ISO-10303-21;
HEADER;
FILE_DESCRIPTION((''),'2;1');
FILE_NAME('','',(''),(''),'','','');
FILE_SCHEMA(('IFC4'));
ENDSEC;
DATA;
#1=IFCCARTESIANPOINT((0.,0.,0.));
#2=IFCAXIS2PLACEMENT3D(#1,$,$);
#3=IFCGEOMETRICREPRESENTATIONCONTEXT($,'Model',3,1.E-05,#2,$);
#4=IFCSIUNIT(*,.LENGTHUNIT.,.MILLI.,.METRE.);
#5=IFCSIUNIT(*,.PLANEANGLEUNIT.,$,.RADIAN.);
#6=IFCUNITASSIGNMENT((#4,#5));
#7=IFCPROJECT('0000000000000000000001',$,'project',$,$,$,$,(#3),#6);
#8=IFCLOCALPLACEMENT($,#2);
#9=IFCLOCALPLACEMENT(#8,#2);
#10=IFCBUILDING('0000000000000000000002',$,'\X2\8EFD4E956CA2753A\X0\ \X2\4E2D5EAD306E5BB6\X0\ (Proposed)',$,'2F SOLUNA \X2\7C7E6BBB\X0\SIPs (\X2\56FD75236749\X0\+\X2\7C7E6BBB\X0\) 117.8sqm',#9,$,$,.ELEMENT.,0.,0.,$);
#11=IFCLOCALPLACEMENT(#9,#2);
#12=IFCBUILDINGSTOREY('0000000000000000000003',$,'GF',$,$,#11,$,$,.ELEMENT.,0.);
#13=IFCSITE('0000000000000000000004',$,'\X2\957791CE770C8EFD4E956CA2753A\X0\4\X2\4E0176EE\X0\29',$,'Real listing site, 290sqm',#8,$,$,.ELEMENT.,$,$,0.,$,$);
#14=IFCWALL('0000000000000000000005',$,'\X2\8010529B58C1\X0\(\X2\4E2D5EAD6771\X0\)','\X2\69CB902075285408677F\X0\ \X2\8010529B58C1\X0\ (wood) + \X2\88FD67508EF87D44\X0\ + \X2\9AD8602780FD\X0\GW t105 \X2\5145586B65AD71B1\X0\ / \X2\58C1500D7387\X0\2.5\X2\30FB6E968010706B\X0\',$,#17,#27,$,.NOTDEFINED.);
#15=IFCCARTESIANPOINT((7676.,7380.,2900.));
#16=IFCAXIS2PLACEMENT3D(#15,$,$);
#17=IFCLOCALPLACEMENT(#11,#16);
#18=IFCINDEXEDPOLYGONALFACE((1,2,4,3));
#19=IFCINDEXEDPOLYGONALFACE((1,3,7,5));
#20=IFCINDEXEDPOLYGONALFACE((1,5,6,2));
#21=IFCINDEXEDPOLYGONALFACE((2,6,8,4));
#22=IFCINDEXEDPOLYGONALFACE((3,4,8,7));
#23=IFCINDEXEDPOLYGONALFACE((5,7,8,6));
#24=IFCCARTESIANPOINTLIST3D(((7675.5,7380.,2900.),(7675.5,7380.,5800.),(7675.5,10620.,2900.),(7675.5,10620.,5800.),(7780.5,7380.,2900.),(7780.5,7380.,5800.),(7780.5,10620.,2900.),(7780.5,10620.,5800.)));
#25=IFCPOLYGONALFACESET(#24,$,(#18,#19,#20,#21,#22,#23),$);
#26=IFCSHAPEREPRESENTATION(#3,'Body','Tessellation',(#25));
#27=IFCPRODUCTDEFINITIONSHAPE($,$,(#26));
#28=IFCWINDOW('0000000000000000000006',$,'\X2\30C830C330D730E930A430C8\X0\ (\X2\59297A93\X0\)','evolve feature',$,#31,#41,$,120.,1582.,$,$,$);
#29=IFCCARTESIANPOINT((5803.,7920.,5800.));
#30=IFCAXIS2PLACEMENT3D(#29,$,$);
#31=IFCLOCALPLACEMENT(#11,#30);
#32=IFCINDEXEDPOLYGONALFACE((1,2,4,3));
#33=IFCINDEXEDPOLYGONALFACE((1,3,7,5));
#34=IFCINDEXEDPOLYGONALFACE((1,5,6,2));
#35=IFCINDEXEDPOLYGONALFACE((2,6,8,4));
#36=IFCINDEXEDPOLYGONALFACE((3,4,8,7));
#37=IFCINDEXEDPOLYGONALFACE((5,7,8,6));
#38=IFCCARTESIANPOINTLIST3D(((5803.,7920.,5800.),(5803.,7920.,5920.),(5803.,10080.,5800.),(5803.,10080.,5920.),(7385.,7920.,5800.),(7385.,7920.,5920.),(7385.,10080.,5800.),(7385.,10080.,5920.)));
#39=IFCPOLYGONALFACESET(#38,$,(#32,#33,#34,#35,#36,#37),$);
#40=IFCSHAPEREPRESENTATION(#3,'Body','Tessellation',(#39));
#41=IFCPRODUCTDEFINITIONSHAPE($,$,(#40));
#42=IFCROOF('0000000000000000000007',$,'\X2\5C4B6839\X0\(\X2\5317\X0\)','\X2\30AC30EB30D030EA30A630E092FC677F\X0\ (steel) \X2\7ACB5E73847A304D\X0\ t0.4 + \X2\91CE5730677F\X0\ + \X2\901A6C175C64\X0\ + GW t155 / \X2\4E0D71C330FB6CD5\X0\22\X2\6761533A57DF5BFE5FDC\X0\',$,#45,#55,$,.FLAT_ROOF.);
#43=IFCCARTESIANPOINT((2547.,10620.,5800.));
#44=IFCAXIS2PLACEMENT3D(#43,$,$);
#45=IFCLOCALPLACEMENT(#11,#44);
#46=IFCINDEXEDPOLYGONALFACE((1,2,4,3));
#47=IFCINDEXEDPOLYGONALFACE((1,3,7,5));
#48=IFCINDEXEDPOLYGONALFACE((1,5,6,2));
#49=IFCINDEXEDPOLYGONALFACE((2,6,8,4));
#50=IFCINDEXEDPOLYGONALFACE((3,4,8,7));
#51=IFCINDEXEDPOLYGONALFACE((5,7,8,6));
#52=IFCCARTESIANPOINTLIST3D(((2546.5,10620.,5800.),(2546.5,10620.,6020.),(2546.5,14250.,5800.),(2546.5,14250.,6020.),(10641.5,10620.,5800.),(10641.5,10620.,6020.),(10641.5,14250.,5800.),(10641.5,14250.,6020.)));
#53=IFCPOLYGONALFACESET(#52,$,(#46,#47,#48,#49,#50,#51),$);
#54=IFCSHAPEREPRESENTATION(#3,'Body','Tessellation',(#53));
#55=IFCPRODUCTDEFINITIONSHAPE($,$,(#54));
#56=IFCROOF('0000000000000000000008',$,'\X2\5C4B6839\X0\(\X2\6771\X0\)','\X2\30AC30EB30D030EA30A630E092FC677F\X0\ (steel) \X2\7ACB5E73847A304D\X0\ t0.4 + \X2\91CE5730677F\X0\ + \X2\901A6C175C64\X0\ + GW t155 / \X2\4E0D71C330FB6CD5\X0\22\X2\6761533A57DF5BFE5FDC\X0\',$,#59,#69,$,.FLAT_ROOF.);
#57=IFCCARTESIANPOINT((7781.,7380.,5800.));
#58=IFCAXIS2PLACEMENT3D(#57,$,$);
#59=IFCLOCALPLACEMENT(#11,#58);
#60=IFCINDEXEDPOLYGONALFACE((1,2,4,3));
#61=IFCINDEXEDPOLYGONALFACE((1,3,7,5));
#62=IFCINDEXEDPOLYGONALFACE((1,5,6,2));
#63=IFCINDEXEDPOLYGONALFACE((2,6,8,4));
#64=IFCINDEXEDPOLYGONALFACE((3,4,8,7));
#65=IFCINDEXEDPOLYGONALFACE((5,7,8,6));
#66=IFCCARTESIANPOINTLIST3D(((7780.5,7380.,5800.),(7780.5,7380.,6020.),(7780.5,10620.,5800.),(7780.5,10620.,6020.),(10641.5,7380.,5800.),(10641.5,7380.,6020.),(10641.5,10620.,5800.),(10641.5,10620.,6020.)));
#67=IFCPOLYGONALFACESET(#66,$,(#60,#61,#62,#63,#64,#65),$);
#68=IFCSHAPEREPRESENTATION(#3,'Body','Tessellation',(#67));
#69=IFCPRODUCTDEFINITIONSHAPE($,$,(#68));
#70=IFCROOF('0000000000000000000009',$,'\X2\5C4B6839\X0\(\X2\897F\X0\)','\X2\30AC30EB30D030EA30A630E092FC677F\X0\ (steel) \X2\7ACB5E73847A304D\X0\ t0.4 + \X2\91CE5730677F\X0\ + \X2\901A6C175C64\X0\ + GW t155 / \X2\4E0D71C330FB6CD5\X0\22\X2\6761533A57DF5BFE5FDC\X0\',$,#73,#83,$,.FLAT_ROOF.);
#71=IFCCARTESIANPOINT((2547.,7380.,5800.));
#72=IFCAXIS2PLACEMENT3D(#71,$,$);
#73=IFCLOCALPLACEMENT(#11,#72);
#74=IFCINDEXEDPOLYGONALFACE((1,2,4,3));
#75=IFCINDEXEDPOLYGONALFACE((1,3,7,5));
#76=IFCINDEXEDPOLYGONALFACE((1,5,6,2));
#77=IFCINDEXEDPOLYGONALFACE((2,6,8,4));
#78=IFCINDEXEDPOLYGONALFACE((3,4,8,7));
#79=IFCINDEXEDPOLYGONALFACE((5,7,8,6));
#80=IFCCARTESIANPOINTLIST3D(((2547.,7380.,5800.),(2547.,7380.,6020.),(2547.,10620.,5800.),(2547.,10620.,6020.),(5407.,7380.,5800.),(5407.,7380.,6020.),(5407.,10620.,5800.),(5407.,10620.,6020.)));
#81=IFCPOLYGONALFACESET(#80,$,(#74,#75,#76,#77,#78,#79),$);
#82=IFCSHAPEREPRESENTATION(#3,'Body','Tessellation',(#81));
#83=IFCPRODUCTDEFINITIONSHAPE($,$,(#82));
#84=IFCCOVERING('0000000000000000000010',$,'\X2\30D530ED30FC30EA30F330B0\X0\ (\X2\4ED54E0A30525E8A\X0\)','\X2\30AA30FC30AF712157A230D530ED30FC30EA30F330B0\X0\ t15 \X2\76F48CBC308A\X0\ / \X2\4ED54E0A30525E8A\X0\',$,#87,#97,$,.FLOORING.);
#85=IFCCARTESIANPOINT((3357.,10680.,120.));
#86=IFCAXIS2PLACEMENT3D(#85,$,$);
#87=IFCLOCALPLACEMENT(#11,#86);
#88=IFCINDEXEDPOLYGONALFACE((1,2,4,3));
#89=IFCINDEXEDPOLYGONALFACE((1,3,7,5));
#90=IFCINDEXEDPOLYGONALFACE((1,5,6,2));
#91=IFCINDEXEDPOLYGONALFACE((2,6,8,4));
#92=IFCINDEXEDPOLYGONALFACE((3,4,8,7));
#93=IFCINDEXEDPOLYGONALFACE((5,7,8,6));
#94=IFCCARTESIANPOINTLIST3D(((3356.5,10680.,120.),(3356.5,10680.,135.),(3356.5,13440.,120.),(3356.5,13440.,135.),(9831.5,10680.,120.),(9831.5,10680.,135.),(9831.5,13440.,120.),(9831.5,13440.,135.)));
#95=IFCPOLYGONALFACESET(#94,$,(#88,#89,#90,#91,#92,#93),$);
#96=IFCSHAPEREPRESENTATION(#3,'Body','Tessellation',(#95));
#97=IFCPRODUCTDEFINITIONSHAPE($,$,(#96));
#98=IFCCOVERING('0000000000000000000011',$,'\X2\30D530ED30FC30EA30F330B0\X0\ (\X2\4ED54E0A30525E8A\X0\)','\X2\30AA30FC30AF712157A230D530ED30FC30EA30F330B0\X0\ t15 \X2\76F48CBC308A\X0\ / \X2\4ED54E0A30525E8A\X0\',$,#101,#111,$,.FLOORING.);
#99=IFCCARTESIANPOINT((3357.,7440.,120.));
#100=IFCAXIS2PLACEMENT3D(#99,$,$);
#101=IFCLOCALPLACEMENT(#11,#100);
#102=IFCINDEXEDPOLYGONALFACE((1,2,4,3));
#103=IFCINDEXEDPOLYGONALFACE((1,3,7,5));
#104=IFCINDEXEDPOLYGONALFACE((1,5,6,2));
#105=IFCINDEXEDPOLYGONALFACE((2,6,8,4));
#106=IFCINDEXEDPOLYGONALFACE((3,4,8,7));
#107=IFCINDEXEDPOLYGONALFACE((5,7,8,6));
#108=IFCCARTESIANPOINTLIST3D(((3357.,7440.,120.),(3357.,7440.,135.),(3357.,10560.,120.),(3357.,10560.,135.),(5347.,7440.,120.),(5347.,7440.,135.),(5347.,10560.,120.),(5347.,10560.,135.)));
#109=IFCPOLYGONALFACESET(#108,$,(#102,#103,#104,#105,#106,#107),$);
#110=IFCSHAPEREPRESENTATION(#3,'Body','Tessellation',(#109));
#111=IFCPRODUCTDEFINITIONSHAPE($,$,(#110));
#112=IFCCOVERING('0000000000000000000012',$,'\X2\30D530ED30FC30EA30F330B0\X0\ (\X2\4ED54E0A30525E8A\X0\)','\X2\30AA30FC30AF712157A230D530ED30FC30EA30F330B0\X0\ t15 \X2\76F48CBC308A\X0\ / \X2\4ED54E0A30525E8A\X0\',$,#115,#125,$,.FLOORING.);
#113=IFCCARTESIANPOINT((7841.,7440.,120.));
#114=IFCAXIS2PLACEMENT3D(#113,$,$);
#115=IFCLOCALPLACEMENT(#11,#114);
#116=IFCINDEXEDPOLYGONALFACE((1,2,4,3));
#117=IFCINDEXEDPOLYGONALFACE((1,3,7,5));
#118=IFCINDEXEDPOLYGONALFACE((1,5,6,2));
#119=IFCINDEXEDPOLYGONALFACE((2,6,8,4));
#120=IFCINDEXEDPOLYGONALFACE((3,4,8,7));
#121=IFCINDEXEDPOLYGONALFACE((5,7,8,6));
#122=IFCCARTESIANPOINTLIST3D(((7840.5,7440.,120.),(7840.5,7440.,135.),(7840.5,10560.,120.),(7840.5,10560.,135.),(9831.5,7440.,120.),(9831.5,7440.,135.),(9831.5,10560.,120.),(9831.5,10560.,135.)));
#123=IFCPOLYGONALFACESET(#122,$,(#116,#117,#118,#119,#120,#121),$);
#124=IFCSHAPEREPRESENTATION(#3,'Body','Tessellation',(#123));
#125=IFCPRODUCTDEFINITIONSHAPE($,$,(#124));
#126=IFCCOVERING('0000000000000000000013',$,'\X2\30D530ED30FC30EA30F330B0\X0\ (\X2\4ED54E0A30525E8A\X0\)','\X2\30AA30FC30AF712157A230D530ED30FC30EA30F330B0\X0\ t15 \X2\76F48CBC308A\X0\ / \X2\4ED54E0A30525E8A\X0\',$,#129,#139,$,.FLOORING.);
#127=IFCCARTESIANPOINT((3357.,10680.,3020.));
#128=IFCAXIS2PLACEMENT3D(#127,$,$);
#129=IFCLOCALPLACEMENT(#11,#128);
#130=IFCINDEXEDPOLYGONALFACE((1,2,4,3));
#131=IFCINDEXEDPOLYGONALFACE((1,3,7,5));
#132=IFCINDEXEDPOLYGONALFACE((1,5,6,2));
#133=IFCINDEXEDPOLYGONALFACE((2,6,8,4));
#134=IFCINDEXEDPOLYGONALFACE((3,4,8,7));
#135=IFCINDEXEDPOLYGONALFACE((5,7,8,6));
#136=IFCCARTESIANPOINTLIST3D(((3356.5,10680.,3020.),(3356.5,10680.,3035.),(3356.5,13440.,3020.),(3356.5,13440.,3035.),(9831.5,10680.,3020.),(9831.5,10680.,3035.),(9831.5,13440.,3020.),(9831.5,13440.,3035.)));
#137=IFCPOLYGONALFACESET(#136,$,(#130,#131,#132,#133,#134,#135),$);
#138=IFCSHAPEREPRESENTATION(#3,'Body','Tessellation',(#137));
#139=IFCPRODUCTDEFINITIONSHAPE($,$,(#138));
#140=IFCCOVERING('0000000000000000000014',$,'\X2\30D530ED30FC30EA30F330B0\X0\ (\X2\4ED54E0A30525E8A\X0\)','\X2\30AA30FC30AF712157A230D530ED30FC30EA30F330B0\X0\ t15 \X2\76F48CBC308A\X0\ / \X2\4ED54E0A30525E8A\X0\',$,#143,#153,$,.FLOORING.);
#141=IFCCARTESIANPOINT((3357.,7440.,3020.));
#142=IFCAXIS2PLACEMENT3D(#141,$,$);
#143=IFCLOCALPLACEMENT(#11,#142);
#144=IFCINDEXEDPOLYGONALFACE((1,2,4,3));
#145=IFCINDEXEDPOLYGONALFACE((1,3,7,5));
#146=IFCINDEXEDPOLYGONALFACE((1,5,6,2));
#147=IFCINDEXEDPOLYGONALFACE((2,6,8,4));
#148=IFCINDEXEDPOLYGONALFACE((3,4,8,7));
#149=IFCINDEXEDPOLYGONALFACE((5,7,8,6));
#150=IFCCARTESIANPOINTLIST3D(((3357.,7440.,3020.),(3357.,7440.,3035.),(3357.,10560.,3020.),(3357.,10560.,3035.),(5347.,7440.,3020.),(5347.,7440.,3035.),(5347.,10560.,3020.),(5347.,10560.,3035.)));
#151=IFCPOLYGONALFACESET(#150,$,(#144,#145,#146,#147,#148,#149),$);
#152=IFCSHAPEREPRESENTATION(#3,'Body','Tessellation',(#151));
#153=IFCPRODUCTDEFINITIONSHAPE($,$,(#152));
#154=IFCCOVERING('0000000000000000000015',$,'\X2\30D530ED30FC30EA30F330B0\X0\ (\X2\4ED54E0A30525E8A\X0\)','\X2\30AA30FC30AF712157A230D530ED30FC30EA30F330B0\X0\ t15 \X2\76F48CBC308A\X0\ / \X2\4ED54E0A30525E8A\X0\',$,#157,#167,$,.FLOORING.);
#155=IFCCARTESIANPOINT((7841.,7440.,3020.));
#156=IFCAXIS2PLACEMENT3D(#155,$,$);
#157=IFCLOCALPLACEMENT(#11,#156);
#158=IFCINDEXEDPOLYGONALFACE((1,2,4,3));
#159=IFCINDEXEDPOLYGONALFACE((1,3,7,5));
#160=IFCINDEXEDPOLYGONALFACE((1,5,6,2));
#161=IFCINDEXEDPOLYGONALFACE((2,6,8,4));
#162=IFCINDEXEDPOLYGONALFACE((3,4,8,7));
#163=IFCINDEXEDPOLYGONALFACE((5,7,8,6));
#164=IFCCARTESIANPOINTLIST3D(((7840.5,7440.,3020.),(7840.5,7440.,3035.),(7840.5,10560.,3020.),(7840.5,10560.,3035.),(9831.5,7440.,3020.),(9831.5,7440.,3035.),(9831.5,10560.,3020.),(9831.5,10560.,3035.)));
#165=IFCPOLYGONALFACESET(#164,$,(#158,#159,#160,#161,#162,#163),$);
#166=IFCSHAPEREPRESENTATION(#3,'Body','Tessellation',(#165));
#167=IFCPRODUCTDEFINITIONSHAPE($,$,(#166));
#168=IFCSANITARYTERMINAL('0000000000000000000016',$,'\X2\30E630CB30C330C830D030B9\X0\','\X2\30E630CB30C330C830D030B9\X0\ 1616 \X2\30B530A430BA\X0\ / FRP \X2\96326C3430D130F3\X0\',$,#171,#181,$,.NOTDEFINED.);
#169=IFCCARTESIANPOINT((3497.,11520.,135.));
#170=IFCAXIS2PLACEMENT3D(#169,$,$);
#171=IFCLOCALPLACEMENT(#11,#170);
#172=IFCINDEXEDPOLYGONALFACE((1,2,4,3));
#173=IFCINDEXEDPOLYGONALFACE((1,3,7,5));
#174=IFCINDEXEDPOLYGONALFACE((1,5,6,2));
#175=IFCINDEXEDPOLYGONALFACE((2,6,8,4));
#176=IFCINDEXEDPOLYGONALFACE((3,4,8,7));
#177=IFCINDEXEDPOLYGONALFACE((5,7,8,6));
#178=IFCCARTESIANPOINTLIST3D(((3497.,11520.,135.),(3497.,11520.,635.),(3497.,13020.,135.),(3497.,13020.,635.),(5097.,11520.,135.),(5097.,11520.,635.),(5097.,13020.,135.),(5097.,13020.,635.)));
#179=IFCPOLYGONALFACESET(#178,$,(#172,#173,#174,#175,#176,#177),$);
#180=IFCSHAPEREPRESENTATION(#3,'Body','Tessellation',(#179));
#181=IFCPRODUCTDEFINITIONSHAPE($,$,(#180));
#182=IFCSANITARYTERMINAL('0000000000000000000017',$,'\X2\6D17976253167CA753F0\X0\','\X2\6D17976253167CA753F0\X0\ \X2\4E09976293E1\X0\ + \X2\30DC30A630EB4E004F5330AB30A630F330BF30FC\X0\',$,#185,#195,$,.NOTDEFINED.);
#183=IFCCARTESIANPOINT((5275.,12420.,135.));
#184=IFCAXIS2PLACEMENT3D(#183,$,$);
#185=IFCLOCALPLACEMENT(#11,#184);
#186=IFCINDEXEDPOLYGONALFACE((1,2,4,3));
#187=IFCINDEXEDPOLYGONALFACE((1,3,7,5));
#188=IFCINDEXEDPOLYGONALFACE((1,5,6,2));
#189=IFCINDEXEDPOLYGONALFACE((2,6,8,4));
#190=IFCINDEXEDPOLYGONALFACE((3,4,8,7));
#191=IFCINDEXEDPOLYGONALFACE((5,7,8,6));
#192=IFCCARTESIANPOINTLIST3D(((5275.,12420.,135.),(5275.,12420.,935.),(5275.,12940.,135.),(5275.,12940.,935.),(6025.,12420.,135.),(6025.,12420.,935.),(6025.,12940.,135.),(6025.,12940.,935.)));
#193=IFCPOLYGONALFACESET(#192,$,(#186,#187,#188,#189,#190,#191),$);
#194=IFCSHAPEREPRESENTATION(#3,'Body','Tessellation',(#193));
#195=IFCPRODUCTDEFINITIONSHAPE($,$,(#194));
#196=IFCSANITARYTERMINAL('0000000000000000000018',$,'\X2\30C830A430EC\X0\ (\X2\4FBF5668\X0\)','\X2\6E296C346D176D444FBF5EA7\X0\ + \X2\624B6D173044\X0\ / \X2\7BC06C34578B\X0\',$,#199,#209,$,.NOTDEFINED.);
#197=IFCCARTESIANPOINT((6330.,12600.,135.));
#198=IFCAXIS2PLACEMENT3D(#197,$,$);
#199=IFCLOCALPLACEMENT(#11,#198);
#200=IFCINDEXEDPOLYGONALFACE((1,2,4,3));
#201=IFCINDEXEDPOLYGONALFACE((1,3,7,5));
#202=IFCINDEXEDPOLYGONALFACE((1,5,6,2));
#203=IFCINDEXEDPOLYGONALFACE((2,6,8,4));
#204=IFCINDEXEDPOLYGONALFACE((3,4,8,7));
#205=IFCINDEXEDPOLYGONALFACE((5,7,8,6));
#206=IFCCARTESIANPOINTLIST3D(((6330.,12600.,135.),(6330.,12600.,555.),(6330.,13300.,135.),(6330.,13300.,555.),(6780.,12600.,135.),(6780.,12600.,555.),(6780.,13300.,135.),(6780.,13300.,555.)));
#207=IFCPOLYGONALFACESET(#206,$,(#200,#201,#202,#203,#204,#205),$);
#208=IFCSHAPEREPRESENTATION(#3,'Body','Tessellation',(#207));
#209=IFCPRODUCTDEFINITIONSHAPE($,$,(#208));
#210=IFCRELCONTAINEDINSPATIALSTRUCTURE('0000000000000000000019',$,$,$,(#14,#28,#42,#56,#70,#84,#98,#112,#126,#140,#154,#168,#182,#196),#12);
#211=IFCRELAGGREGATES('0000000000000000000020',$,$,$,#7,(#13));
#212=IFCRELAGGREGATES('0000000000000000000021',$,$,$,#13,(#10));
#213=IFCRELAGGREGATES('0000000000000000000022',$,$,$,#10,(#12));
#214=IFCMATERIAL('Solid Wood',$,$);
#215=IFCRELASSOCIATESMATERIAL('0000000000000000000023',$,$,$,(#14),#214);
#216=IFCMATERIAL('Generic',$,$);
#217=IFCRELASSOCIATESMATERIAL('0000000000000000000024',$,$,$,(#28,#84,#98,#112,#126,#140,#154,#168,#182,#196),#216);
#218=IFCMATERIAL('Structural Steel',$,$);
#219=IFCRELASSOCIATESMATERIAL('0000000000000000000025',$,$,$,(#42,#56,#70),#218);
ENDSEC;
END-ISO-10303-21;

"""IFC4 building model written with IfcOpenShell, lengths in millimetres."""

from ifc_helpers import new_model, si_unit, frame, frame_2d, origin, place, context, project, spatial, rectangle, extrude, material, element, save


model = new_model("IFC4")

# Units and contexts
model_context = context("Model", 3, precision=1e-05, world=origin())
ifc_project = project(units=[si_unit("LENGTHUNIT", "METRE", prefix="MILLI"), si_unit("PLANEANGLEUNIT", "RADIAN")], contexts=[model_context])

# Site, building, storey
site_placement = place(None, origin())
site = spatial("IfcSite", under=ifc_project, at=site_placement, Name="長野県軽井沢町4丁目29", ObjectType="Real listing site, 290sqm", CompositionType="ELEMENT", RefElevation=0.0)
building_placement = place(site_placement, origin())
building = spatial("IfcBuilding", under=site, at=building_placement, Name="軽井沢町 中庭の家 (Proposed)", ObjectType="2F SOLUNA 籾殻SIPs (国産杉+籾殻) 117.8sqm", CompositionType="ELEMENT", ElevationOfRefHeight=0.0, ElevationOfTerrain=0.0)
storey_placement = place(building_placement, origin())
storey = spatial("IfcBuildingStorey", under=building, at=storey_placement, Name="GF", CompositionType="ELEMENT", Elevation=0.0)

# Shared definitions
ifc_material_1 = material(Name="Solid Wood")

# Wall
wall_1_placement = place(storey_placement, frame((7676.0, 7380.0, 2900.0)))
element("IfcWall", 1, at=wall_1_placement, inside=storey, material=ifc_material_1, Name="耐力壁(中庭東)", Description="構造用合板 耐力壁 (wood) + 製材軸組 + 高性能GW t105 充填断熱 / 壁倍率2.5・準耐火", PredefinedType="NOTDEFINED", context=model_context, shape_type="SweptSolid", body=[
    extrude(rectangle(XDim=105.0, YDim=3240.0, at=frame_2d((52.0, 1620.0))), frame((7676.0, 7380.0, 2900.0)), (0.0, 0.0, 1.0), 2900.0),
])

# Window
ifc_material_2 = material(Name="Generic")
window_1_placement = place(storey_placement, frame((5803.0, 7920.0, 5800.0)))
element("IfcWindow", 2, at=window_1_placement, inside=storey, material=ifc_material_2, Name="トップライト (天窓)", Description="evolve feature", OverallHeight=120.0, OverallWidth=1582.0, context=model_context, shape_type="SweptSolid", body=[
    extrude(rectangle(XDim=1582.0, YDim=2160.0, at=frame_2d((791.0, 1080.0))), frame((5803.0, 7920.0, 5800.0)), (0.0, 0.0, 1.0), 120.0),
])

# Roofs
ifc_material_3 = material(Name="Structural Steel")
roof_1_placement = place(storey_placement, frame((2547.0, 10620.0, 5800.0)))
element("IfcRoof", 3, at=roof_1_placement, inside=storey, material=ifc_material_3, Name="屋根(北)", Description="ガルバリウム鋼板 (steel) 立平葺き t0.4 + 野地板 + 通気層 + GW t155 / 不燃・法22条区域対応", PredefinedType="FLAT_ROOF", context=model_context, shape_type="SweptSolid", body=[
    extrude(rectangle(XDim=8095.0, YDim=3630.0, at=frame_2d((4047.0, 1815.0))), frame((2547.0, 10620.0, 5800.0)), (0.0, 0.0, 1.0), 220.0),
])
roof_2_placement = place(storey_placement, frame((7781.0, 7380.0, 5800.0)))
element("IfcRoof", 4, at=roof_2_placement, inside=storey, material=ifc_material_3, Name="屋根(東)", Description="ガルバリウム鋼板 (steel) 立平葺き t0.4 + 野地板 + 通気層 + GW t155 / 不燃・法22条区域対応", PredefinedType="FLAT_ROOF", context=model_context, shape_type="SweptSolid", body=[
    extrude(rectangle(XDim=2861.0, YDim=3240.0, at=frame_2d((1430.0, 1620.0))), frame((7781.0, 7380.0, 5800.0)), (0.0, 0.0, 1.0), 220.0),
])
roof_3_placement = place(storey_placement, frame((2547.0, 7380.0, 5800.0)))
element("IfcRoof", 5, at=roof_3_placement, inside=storey, material=ifc_material_3, Name="屋根(西)", Description="ガルバリウム鋼板 (steel) 立平葺き t0.4 + 野地板 + 通気層 + GW t155 / 不燃・法22条区域対応", PredefinedType="FLAT_ROOF", context=model_context, shape_type="SweptSolid", body=[
    extrude(rectangle(XDim=2860.0, YDim=3240.0, at=frame_2d((1430.0, 1620.0))), frame((2547.0, 7380.0, 5800.0)), (0.0, 0.0, 1.0), 220.0),
])

# Coverings
covering_1_placement = place(storey_placement, frame((3357.0, 10680.0, 120.0)))
element("IfcCovering", 6, at=covering_1_placement, inside=storey, material=ifc_material_2, Name="フローリング (仕上げ床)", Description="オーク無垢フローリング t15 直貼り / 仕上げ床", PredefinedType="FLOORING", context=model_context, shape_type="SweptSolid", body=[
    extrude(rectangle(XDim=6475.0, YDim=2760.0, at=frame_2d((3237.0, 1380.0))), frame((3357.0, 10680.0, 120.0)), (0.0, 0.0, 1.0), 15.0),
])
covering_2_placement = place(storey_placement, frame((3357.0, 7440.0, 120.0)))
element("IfcCovering", 7, at=covering_2_placement, inside=storey, material=ifc_material_2, Name="フローリング (仕上げ床)", Description="オーク無垢フローリング t15 直貼り / 仕上げ床", PredefinedType="FLOORING", context=model_context, shape_type="SweptSolid", body=[
    extrude(rectangle(XDim=1990.0, YDim=3120.0, at=frame_2d((995.0, 1560.0))), frame((3357.0, 7440.0, 120.0)), (0.0, 0.0, 1.0), 15.0),
])
covering_3_placement = place(storey_placement, frame((7841.0, 7440.0, 120.0)))
element("IfcCovering", 8, at=covering_3_placement, inside=storey, material=ifc_material_2, Name="フローリング (仕上げ床)", Description="オーク無垢フローリング t15 直貼り / 仕上げ床", PredefinedType="FLOORING", context=model_context, shape_type="SweptSolid", body=[
    extrude(rectangle(XDim=1991.0, YDim=3120.0, at=frame_2d((995.0, 1560.0))), frame((7841.0, 7440.0, 120.0)), (0.0, 0.0, 1.0), 15.0),
])
covering_4_placement = place(storey_placement, frame((3357.0, 10680.0, 3020.0)))
element("IfcCovering", 9, at=covering_4_placement, inside=storey, material=ifc_material_2, Name="フローリング (仕上げ床)", Description="オーク無垢フローリング t15 直貼り / 仕上げ床", PredefinedType="FLOORING", context=model_context, shape_type="SweptSolid", body=[
    extrude(rectangle(XDim=6475.0, YDim=2760.0, at=frame_2d((3237.0, 1380.0))), frame((3357.0, 10680.0, 3020.0)), (0.0, 0.0, 1.0), 15.0),
])
covering_5_placement = place(storey_placement, frame((3357.0, 7440.0, 3020.0)))
element("IfcCovering", 10, at=covering_5_placement, inside=storey, material=ifc_material_2, Name="フローリング (仕上げ床)", Description="オーク無垢フローリング t15 直貼り / 仕上げ床", PredefinedType="FLOORING", context=model_context, shape_type="SweptSolid", body=[
    extrude(rectangle(XDim=1990.0, YDim=3120.0, at=frame_2d((995.0, 1560.0))), frame((3357.0, 7440.0, 3020.0)), (0.0, 0.0, 1.0), 15.0),
])
covering_6_placement = place(storey_placement, frame((7841.0, 7440.0, 3020.0)))
element("IfcCovering", 11, at=covering_6_placement, inside=storey, material=ifc_material_2, Name="フローリング (仕上げ床)", Description="オーク無垢フローリング t15 直貼り / 仕上げ床", PredefinedType="FLOORING", context=model_context, shape_type="SweptSolid", body=[
    extrude(rectangle(XDim=1991.0, YDim=3120.0, at=frame_2d((995.0, 1560.0))), frame((7841.0, 7440.0, 3020.0)), (0.0, 0.0, 1.0), 15.0),
])

# Sanitary terminals
sanitary_terminal_1_placement = place(storey_placement, frame((3497.0, 11520.0, 135.0)))
element("IfcSanitaryTerminal", 12, at=sanitary_terminal_1_placement, inside=storey, material=ifc_material_2, Name="ユニットバス", Description="ユニットバス 1616 サイズ / FRP 防水パン", PredefinedType="NOTDEFINED", context=model_context, shape_type="SweptSolid", body=[
    extrude(rectangle(XDim=1600.0, YDim=1500.0, at=frame_2d((800.0, 750.0))), frame((3497.0, 11520.0, 135.0)), (0.0, 0.0, 1.0), 500.0),
])
sanitary_terminal_2_placement = place(storey_placement, frame((5275.0, 12420.0, 135.0)))
element("IfcSanitaryTerminal", 13, at=sanitary_terminal_2_placement, inside=storey, material=ifc_material_2, Name="洗面化粧台", Description="洗面化粧台 三面鏡 + ボウル一体カウンター", PredefinedType="NOTDEFINED", context=model_context, shape_type="SweptSolid", body=[
    extrude(rectangle(XDim=750.0, YDim=520.0, at=frame_2d((375.0, 260.0))), frame((5275.0, 12420.0, 135.0)), (0.0, 0.0, 1.0), 800.0),
])
sanitary_terminal_3_placement = place(storey_placement, frame((6330.0, 12600.0, 135.0)))
element("IfcSanitaryTerminal", 14, at=sanitary_terminal_3_placement, inside=storey, material=ifc_material_2, Name="トイレ (便器)", Description="温水洗浄便座 + 手洗い / 節水型", PredefinedType="NOTDEFINED", context=model_context, shape_type="SweptSolid", body=[
    extrude(rectangle(XDim=450.0, YDim=700.0, at=frame_2d((225.0, 350.0))), frame((6330.0, 12600.0, 135.0)), (0.0, 0.0, 1.0), 420.0),
])

save(model, "model.ifc")
